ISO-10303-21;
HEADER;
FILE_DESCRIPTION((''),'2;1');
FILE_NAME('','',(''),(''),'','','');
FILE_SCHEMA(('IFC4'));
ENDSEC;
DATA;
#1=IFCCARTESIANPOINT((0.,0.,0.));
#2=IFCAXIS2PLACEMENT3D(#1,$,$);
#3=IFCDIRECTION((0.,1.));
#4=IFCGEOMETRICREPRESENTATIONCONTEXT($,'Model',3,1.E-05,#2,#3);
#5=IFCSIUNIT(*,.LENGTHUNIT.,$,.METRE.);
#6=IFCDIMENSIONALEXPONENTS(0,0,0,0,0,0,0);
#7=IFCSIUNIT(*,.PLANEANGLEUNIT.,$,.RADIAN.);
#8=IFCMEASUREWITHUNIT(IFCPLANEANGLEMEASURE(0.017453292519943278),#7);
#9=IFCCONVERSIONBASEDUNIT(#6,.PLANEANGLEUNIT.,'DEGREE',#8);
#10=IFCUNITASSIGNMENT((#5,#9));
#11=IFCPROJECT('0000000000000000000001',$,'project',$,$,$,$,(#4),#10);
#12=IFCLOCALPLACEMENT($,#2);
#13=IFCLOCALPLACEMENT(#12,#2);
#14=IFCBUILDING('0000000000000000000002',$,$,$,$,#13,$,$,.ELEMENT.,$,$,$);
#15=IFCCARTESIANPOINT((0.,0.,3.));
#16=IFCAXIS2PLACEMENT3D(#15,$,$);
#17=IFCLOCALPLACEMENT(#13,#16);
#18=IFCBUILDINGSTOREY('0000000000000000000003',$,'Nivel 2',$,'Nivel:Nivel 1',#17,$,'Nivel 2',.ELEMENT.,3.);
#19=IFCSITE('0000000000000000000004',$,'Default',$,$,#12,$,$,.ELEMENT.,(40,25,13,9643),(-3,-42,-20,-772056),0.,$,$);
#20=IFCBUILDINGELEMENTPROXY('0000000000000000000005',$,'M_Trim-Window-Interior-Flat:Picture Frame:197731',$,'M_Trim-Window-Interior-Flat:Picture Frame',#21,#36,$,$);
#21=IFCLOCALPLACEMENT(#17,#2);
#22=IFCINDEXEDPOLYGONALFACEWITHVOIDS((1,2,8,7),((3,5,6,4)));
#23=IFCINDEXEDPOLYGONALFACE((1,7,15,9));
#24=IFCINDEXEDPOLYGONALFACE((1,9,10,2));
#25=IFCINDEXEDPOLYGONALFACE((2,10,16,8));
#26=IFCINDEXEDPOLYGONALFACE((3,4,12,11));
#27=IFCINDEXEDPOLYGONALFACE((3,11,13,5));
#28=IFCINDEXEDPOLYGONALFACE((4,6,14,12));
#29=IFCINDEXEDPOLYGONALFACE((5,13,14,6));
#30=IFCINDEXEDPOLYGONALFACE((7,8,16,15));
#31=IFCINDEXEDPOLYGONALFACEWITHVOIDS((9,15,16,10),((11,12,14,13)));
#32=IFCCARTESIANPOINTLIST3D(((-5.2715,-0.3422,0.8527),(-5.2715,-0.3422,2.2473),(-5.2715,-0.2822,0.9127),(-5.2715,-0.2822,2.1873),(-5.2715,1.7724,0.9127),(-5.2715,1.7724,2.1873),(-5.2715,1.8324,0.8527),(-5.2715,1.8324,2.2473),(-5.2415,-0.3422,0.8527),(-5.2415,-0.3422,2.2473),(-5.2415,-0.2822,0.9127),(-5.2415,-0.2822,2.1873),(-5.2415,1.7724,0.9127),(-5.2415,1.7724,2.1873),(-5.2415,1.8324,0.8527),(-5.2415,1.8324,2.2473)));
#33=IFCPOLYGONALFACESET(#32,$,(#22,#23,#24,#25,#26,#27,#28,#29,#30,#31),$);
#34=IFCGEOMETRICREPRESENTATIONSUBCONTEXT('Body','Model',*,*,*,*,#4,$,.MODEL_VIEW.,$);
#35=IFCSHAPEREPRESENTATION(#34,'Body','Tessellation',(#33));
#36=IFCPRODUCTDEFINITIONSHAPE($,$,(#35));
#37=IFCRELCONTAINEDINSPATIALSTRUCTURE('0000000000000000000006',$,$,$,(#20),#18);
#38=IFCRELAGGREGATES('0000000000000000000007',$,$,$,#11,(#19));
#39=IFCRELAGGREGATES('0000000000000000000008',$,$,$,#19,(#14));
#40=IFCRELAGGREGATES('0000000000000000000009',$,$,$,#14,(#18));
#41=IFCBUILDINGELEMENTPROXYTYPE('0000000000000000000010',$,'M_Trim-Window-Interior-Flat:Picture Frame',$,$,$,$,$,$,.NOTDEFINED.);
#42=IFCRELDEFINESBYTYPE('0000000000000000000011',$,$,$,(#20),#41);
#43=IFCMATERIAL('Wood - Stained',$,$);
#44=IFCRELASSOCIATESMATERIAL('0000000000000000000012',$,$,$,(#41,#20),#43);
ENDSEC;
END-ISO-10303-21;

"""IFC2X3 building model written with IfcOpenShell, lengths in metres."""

from ifc_helpers import new_model, entity, si_unit, converted_unit, direction, frame, origin, place, context, subcontext, project, spatial, polyline, outline, extrude, source, transform, mapped, material, type_object, type_shapes, element, save


model = new_model("IFC2X3")

# Units and contexts
model_context = context("Model", 3, precision=1e-05, world=origin(), true_north=direction((0.0, 1.0)))
body_context = subcontext(model_context, "Body", "Model", "MODEL_VIEW")
ifc_project = project(units=[si_unit("LENGTHUNIT", "METRE"), converted_unit("PLANEANGLEUNIT", "DEGREE", entity("IfcPlaneAngleMeasure", 0.017453292519943278), si_unit("PLANEANGLEUNIT", "RADIAN"), dimensions=[0, 0, 0, 0, 0, 0, 0])], contexts=[model_context])

# Site, building, storey
site_placement = place(None, origin())
site = spatial("IfcSite", under=ifc_project, at=site_placement, Name="Default", CompositionType="ELEMENT", RefLatitude=(40, 25, 13, 9643), RefLongitude=(-3, -42, -20, -772056), RefElevation=0.0)
building_placement = place(site_placement, origin())
building = spatial("IfcBuilding", under=site, at=building_placement, CompositionType="ELEMENT")
storey_placement = place(building_placement, frame((0.0, 0.0, 3.0)))
storey = spatial("IfcBuildingStorey", under=building, at=storey_placement, Name="Nivel 2", ObjectType="Nivel:Nivel 1", LongName="Nivel 2", CompositionType="ELEMENT", Elevation=3.0)

# Building element proxy
ifc_material_1 = material(Name="Wood - Stained")
building_element_proxy_type_1 = type_object("IfcBuildingElementProxyType", Name="M_Trim-Window-Interior-Flat:Picture Frame", PredefinedType="NOTDEFINED", material=ifc_material_1)
shared_shape_1 = source(origin(), body_context, "Body", "SweptSolid", [
    extrude(outline(polyline([(-1.0873, -0.6973), (1.0873, -0.6973), (1.0873, 0.6973), (-1.0873, 0.6973), (-1.0873, -0.6973)]), holes=[polyline([(-1.0273, -0.6373), (-1.0273, 0.6373), (1.0273, 0.6373), (1.0273, -0.6373), (-1.0273, -0.6373)])]), frame((0.0, -0.65, 0.0), z_axis=(0.0, 0.0, 1.0), x_axis=(-1.0, 0.0, 0.0)), (0.0, 0.0, 1.0), 0.03),
])
type_shapes(building_element_proxy_type_1, [shared_shape_1])
proxy_1_placement = place(storey_placement, frame((-5.2715, 0.7451, 2.2), z_axis=(1.0, 0.0, 0.0), x_axis=(0.0, 1.0, 0.0)))
element("IfcBuildingElementProxy", 1, at=proxy_1_placement, inside=storey, type_object=building_element_proxy_type_1, material=ifc_material_1, Name="M_Trim-Window-Interior-Flat:Picture Frame:197731", ObjectType="M_Trim-Window-Interior-Flat:Picture Frame", context=body_context, shape_type="MappedRepresentation", body=[
    mapped(shared_shape_1, transform((0.0, 0.0, 0.0), scale=1.0)),
])

save(model, "model.ifc")
